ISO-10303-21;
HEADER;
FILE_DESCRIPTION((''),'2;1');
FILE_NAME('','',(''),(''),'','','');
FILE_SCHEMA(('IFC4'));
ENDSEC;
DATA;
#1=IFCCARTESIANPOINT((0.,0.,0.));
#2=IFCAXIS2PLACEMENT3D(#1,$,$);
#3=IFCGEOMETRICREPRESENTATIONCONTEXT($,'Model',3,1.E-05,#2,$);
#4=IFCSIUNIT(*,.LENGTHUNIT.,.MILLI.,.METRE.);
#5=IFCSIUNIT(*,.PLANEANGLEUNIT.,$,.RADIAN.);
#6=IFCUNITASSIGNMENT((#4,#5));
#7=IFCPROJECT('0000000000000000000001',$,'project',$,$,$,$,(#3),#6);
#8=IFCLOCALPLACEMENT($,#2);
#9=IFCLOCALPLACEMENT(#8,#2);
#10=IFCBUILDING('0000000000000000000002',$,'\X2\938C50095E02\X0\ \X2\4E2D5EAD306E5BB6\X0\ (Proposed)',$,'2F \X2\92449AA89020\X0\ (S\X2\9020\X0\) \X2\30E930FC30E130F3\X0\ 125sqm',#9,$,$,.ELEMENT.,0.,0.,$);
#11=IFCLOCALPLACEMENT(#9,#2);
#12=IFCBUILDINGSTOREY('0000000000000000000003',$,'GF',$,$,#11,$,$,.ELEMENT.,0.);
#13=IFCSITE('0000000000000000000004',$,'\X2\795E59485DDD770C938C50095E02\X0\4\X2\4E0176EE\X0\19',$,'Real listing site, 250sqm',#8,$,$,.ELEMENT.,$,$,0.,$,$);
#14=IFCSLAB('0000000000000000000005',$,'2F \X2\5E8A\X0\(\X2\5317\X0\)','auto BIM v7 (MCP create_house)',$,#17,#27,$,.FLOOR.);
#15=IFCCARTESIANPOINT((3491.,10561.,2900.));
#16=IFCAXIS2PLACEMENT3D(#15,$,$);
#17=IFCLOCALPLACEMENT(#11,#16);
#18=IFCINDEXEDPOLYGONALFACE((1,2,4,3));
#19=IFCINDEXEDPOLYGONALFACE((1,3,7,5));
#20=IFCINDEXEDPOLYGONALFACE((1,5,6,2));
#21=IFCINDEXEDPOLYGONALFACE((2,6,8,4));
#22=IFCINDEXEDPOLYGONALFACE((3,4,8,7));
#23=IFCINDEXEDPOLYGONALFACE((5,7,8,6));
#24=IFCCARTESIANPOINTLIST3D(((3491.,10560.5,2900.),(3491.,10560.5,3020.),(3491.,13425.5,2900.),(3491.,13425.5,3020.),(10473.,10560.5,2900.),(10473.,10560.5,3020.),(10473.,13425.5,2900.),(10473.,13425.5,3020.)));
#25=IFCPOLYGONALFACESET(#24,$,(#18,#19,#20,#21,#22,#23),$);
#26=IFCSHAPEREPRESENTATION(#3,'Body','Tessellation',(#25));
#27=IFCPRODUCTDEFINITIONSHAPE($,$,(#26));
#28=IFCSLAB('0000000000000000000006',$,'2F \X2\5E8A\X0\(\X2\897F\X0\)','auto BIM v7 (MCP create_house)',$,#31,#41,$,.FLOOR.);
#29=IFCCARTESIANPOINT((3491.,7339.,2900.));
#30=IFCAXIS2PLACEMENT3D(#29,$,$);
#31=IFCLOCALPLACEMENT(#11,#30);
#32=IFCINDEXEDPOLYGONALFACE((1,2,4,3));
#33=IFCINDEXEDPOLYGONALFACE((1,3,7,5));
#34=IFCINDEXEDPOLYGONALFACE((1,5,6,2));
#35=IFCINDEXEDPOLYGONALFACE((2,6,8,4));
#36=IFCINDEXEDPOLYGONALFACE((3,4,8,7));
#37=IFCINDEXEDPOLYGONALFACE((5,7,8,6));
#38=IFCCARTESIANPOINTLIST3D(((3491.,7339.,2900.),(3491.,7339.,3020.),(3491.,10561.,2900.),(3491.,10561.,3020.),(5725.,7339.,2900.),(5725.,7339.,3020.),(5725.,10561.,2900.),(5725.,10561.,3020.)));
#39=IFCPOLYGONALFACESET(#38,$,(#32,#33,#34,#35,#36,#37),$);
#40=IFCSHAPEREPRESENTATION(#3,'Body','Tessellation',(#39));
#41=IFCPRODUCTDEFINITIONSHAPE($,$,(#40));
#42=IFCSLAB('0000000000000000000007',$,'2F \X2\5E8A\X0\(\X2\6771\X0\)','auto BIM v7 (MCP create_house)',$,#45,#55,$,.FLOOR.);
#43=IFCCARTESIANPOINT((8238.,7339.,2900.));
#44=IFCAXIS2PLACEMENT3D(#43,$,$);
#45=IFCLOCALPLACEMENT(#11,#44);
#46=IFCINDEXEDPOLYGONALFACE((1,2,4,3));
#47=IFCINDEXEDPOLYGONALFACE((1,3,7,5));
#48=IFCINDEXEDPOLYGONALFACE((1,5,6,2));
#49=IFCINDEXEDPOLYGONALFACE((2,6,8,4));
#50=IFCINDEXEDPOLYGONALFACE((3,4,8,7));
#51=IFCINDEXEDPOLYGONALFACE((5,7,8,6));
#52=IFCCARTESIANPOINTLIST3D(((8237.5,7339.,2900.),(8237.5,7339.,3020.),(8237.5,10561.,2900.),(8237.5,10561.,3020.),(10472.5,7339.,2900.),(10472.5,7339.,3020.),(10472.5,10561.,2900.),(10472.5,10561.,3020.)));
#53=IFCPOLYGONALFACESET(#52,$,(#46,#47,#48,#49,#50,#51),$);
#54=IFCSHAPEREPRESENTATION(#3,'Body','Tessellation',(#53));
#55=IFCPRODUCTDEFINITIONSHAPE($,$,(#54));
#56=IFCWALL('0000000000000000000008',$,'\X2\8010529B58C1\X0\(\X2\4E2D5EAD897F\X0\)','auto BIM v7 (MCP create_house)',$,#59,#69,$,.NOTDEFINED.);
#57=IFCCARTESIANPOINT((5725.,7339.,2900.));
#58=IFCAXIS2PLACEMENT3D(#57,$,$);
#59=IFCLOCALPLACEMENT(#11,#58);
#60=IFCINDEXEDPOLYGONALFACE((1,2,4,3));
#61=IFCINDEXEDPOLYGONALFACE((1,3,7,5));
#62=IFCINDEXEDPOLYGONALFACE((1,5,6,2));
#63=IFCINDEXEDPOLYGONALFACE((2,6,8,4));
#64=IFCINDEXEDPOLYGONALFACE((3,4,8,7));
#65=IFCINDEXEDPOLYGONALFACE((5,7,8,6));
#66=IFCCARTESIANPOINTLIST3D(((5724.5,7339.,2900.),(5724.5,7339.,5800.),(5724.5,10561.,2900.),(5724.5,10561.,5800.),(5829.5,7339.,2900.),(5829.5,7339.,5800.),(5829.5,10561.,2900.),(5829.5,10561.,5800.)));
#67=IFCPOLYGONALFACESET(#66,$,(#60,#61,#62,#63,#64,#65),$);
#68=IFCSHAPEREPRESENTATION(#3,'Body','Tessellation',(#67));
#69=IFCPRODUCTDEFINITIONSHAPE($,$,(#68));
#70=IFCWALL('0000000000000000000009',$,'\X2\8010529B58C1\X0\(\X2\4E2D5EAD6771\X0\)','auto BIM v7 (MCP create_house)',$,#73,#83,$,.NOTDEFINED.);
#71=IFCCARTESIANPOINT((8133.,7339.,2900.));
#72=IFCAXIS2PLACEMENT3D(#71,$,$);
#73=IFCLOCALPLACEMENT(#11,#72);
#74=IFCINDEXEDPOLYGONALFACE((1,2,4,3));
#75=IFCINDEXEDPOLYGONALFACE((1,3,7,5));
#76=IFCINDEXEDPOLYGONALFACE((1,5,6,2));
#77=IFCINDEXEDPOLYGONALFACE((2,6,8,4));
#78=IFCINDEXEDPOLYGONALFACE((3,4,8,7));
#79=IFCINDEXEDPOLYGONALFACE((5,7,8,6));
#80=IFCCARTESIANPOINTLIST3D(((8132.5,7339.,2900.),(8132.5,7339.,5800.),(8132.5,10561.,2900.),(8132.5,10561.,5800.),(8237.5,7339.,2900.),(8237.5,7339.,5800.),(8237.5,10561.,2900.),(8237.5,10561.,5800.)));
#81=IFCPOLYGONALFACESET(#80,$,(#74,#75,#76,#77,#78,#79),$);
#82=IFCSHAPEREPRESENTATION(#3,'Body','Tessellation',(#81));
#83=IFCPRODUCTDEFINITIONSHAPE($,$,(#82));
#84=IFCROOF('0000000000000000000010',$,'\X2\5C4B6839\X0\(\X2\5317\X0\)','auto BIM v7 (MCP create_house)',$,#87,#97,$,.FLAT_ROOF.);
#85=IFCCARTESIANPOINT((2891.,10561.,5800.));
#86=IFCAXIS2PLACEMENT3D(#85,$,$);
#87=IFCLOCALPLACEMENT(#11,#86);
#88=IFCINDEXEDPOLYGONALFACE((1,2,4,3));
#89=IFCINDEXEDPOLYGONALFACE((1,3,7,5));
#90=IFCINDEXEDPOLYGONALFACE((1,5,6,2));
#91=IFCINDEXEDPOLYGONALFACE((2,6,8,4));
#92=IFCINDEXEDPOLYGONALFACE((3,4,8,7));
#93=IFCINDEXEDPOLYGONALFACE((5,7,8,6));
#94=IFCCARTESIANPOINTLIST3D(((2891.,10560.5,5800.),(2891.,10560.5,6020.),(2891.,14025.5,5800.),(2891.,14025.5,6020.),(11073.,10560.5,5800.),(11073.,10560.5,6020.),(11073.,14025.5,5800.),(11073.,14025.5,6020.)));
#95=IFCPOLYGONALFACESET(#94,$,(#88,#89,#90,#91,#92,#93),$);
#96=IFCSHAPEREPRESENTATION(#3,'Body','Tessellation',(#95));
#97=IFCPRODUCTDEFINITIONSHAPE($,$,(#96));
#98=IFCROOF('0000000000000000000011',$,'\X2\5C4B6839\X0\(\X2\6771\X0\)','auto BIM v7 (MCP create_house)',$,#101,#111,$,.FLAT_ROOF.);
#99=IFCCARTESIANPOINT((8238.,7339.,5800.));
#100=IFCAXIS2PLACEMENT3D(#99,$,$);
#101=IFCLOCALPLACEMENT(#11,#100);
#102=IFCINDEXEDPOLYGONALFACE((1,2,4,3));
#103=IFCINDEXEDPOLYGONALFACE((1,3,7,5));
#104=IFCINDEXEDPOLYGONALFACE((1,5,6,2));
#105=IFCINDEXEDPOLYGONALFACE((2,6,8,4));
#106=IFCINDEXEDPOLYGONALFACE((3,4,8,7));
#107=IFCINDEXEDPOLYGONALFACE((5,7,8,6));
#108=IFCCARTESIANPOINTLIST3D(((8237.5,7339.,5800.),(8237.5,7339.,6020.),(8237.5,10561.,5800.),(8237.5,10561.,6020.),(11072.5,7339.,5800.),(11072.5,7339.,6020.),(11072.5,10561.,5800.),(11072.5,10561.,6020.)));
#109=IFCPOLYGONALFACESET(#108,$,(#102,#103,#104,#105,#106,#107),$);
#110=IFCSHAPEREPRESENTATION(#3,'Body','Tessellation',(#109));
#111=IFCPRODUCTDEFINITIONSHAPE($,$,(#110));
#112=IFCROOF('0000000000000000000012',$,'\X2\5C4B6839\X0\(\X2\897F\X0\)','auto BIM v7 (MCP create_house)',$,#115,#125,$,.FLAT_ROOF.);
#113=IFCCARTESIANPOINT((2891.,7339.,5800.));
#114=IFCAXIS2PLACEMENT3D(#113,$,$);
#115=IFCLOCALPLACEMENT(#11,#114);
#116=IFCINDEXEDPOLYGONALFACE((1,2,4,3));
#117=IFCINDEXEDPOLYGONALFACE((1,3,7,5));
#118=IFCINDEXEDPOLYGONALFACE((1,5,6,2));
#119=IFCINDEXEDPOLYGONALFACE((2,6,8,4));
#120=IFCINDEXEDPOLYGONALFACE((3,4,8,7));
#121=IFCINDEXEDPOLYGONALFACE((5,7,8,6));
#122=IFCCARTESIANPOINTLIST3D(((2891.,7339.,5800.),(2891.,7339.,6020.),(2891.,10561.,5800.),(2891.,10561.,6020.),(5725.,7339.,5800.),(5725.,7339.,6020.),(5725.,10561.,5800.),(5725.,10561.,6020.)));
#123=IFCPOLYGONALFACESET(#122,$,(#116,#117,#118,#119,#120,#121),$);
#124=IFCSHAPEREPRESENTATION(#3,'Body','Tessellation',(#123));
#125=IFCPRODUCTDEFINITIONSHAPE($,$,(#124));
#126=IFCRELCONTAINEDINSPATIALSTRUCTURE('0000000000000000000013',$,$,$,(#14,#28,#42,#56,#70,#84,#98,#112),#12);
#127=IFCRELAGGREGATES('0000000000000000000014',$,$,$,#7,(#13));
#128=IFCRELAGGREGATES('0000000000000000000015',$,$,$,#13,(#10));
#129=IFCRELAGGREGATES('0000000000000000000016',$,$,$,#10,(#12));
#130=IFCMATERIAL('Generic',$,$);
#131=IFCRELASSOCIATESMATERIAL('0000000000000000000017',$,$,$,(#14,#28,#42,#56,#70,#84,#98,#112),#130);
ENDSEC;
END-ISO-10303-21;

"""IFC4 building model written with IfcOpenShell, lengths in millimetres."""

from ifc_helpers import new_model, si_unit, frame, frame_2d, origin, place, context, project, spatial, rectangle, extrude, material, element, save


model = new_model("IFC4")

# Units and contexts
model_context = context("Model", 3, precision=1e-05, world=origin())
ifc_project = project(units=[si_unit("LENGTHUNIT", "METRE", prefix="MILLI"), si_unit("PLANEANGLEUNIT", "RADIAN")], contexts=[model_context])

# Site, building, storey
site_placement = place(None, origin())
site = spatial("IfcSite", under=ifc_project, at=site_placement, Name="神奈川県鎌倉市4丁目19", ObjectType="Real listing site, 250sqm", CompositionType="ELEMENT", RefElevation=0.0)
building_placement = place(site_placement, origin())
building = spatial("IfcBuilding", under=site, at=building_placement, Name="鎌倉市 中庭の家 (Proposed)", ObjectType="2F 鉄骨造 (S造) ラーメン 125sqm", CompositionType="ELEMENT", ElevationOfRefHeight=0.0, ElevationOfTerrain=0.0)
storey_placement = place(building_placement, origin())
storey = spatial("IfcBuildingStorey", under=building, at=storey_placement, Name="GF", CompositionType="ELEMENT", Elevation=0.0)

# Slabs
ifc_material = material(Name="Generic")
slab_1_placement = place(storey_placement, frame((3491.0, 10561.0, 2900.0)))
element("IfcSlab", 1, at=slab_1_placement, inside=storey, material=ifc_material, Name="2F 床(北)", Description="auto BIM v7 (MCP create_house)", PredefinedType="FLOOR", context=model_context, shape_type="SweptSolid", body=[
    extrude(rectangle(XDim=6982.0, YDim=2865.0, at=frame_2d((3491.0, 1432.0))), frame((3491.0, 10561.0, 2900.0)), (0.0, 0.0, 1.0), 120.0),
])
slab_2_placement = place(storey_placement, frame((3491.0, 7339.0, 2900.0)))
element("IfcSlab", 2, at=slab_2_placement, inside=storey, material=ifc_material, Name="2F 床(西)", Description="auto BIM v7 (MCP create_house)", PredefinedType="FLOOR", context=model_context, shape_type="SweptSolid", body=[
    extrude(rectangle(XDim=2234.0, YDim=3222.0, at=frame_2d((1117.0, 1611.0))), frame((3491.0, 7339.0, 2900.0)), (0.0, 0.0, 1.0), 120.0),
])
slab_3_placement = place(storey_placement, frame((8238.0, 7339.0, 2900.0)))
element("IfcSlab", 3, at=slab_3_placement, inside=storey, material=ifc_material, Name="2F 床(東)", Description="auto BIM v7 (MCP create_house)", PredefinedType="FLOOR", context=model_context, shape_type="SweptSolid", body=[
    extrude(rectangle(XDim=2235.0, YDim=3222.0, at=frame_2d((1117.0, 1611.0))), frame((8238.0, 7339.0, 2900.0)), (0.0, 0.0, 1.0), 120.0),
])

# Walls
wall_1_placement = place(storey_placement, frame((5725.0, 7339.0, 2900.0)))
element("IfcWall", 4, at=wall_1_placement, inside=storey, material=ifc_material, Name="耐力壁(中庭西)", Description="auto BIM v7 (MCP create_house)", PredefinedType="NOTDEFINED", context=model_context, shape_type="SweptSolid", body=[
    extrude(rectangle(XDim=105.0, YDim=3222.0, at=frame_2d((52.0, 1611.0))), frame((5725.0, 7339.0, 2900.0)), (0.0, 0.0, 1.0), 2900.0),
])
wall_2_placement = place(storey_placement, frame((8133.0, 7339.0, 2900.0)))
element("IfcWall", 5, at=wall_2_placement, inside=storey, material=ifc_material, Name="耐力壁(中庭東)", Description="auto BIM v7 (MCP create_house)", PredefinedType="NOTDEFINED", context=model_context, shape_type="SweptSolid", body=[
    extrude(rectangle(XDim=105.0, YDim=3222.0, at=frame_2d((52.0, 1611.0))), frame((8133.0, 7339.0, 2900.0)), (0.0, 0.0, 1.0), 2900.0),
])

# Roofs
roof_1_placement = place(storey_placement, frame((2891.0, 10561.0, 5800.0)))
element("IfcRoof", 6, at=roof_1_placement, inside=storey, material=ifc_material, Name="屋根(北)", Description="auto BIM v7 (MCP create_house)", PredefinedType="FLAT_ROOF", context=model_context, shape_type="SweptSolid", body=[
    extrude(rectangle(XDim=8182.0, YDim=3465.0, at=frame_2d((4091.0, 1732.0))), frame((2891.0, 10561.0, 5800.0)), (0.0, 0.0, 1.0), 220.0),
])
roof_2_placement = place(storey_placement, frame((8238.0, 7339.0, 5800.0)))
element("IfcRoof", 7, at=roof_2_placement, inside=storey, material=ifc_material, Name="屋根(東)", Description="auto BIM v7 (MCP create_house)", PredefinedType="FLAT_ROOF", context=model_context, shape_type="SweptSolid", body=[
    extrude(rectangle(XDim=2835.0, YDim=3222.0, at=frame_2d((1417.0, 1611.0))), frame((8238.0, 7339.0, 5800.0)), (0.0, 0.0, 1.0), 220.0),
])
roof_3_placement = place(storey_placement, frame((2891.0, 7339.0, 5800.0)))
element("IfcRoof", 8, at=roof_3_placement, inside=storey, material=ifc_material, Name="屋根(西)", Description="auto BIM v7 (MCP create_house)", PredefinedType="FLAT_ROOF", context=model_context, shape_type="SweptSolid", body=[
    extrude(rectangle(XDim=2834.0, YDim=3222.0, at=frame_2d((1417.0, 1611.0))), frame((2891.0, 7339.0, 5800.0)), (0.0, 0.0, 1.0), 220.0),
])

save(model, "model.ifc")
